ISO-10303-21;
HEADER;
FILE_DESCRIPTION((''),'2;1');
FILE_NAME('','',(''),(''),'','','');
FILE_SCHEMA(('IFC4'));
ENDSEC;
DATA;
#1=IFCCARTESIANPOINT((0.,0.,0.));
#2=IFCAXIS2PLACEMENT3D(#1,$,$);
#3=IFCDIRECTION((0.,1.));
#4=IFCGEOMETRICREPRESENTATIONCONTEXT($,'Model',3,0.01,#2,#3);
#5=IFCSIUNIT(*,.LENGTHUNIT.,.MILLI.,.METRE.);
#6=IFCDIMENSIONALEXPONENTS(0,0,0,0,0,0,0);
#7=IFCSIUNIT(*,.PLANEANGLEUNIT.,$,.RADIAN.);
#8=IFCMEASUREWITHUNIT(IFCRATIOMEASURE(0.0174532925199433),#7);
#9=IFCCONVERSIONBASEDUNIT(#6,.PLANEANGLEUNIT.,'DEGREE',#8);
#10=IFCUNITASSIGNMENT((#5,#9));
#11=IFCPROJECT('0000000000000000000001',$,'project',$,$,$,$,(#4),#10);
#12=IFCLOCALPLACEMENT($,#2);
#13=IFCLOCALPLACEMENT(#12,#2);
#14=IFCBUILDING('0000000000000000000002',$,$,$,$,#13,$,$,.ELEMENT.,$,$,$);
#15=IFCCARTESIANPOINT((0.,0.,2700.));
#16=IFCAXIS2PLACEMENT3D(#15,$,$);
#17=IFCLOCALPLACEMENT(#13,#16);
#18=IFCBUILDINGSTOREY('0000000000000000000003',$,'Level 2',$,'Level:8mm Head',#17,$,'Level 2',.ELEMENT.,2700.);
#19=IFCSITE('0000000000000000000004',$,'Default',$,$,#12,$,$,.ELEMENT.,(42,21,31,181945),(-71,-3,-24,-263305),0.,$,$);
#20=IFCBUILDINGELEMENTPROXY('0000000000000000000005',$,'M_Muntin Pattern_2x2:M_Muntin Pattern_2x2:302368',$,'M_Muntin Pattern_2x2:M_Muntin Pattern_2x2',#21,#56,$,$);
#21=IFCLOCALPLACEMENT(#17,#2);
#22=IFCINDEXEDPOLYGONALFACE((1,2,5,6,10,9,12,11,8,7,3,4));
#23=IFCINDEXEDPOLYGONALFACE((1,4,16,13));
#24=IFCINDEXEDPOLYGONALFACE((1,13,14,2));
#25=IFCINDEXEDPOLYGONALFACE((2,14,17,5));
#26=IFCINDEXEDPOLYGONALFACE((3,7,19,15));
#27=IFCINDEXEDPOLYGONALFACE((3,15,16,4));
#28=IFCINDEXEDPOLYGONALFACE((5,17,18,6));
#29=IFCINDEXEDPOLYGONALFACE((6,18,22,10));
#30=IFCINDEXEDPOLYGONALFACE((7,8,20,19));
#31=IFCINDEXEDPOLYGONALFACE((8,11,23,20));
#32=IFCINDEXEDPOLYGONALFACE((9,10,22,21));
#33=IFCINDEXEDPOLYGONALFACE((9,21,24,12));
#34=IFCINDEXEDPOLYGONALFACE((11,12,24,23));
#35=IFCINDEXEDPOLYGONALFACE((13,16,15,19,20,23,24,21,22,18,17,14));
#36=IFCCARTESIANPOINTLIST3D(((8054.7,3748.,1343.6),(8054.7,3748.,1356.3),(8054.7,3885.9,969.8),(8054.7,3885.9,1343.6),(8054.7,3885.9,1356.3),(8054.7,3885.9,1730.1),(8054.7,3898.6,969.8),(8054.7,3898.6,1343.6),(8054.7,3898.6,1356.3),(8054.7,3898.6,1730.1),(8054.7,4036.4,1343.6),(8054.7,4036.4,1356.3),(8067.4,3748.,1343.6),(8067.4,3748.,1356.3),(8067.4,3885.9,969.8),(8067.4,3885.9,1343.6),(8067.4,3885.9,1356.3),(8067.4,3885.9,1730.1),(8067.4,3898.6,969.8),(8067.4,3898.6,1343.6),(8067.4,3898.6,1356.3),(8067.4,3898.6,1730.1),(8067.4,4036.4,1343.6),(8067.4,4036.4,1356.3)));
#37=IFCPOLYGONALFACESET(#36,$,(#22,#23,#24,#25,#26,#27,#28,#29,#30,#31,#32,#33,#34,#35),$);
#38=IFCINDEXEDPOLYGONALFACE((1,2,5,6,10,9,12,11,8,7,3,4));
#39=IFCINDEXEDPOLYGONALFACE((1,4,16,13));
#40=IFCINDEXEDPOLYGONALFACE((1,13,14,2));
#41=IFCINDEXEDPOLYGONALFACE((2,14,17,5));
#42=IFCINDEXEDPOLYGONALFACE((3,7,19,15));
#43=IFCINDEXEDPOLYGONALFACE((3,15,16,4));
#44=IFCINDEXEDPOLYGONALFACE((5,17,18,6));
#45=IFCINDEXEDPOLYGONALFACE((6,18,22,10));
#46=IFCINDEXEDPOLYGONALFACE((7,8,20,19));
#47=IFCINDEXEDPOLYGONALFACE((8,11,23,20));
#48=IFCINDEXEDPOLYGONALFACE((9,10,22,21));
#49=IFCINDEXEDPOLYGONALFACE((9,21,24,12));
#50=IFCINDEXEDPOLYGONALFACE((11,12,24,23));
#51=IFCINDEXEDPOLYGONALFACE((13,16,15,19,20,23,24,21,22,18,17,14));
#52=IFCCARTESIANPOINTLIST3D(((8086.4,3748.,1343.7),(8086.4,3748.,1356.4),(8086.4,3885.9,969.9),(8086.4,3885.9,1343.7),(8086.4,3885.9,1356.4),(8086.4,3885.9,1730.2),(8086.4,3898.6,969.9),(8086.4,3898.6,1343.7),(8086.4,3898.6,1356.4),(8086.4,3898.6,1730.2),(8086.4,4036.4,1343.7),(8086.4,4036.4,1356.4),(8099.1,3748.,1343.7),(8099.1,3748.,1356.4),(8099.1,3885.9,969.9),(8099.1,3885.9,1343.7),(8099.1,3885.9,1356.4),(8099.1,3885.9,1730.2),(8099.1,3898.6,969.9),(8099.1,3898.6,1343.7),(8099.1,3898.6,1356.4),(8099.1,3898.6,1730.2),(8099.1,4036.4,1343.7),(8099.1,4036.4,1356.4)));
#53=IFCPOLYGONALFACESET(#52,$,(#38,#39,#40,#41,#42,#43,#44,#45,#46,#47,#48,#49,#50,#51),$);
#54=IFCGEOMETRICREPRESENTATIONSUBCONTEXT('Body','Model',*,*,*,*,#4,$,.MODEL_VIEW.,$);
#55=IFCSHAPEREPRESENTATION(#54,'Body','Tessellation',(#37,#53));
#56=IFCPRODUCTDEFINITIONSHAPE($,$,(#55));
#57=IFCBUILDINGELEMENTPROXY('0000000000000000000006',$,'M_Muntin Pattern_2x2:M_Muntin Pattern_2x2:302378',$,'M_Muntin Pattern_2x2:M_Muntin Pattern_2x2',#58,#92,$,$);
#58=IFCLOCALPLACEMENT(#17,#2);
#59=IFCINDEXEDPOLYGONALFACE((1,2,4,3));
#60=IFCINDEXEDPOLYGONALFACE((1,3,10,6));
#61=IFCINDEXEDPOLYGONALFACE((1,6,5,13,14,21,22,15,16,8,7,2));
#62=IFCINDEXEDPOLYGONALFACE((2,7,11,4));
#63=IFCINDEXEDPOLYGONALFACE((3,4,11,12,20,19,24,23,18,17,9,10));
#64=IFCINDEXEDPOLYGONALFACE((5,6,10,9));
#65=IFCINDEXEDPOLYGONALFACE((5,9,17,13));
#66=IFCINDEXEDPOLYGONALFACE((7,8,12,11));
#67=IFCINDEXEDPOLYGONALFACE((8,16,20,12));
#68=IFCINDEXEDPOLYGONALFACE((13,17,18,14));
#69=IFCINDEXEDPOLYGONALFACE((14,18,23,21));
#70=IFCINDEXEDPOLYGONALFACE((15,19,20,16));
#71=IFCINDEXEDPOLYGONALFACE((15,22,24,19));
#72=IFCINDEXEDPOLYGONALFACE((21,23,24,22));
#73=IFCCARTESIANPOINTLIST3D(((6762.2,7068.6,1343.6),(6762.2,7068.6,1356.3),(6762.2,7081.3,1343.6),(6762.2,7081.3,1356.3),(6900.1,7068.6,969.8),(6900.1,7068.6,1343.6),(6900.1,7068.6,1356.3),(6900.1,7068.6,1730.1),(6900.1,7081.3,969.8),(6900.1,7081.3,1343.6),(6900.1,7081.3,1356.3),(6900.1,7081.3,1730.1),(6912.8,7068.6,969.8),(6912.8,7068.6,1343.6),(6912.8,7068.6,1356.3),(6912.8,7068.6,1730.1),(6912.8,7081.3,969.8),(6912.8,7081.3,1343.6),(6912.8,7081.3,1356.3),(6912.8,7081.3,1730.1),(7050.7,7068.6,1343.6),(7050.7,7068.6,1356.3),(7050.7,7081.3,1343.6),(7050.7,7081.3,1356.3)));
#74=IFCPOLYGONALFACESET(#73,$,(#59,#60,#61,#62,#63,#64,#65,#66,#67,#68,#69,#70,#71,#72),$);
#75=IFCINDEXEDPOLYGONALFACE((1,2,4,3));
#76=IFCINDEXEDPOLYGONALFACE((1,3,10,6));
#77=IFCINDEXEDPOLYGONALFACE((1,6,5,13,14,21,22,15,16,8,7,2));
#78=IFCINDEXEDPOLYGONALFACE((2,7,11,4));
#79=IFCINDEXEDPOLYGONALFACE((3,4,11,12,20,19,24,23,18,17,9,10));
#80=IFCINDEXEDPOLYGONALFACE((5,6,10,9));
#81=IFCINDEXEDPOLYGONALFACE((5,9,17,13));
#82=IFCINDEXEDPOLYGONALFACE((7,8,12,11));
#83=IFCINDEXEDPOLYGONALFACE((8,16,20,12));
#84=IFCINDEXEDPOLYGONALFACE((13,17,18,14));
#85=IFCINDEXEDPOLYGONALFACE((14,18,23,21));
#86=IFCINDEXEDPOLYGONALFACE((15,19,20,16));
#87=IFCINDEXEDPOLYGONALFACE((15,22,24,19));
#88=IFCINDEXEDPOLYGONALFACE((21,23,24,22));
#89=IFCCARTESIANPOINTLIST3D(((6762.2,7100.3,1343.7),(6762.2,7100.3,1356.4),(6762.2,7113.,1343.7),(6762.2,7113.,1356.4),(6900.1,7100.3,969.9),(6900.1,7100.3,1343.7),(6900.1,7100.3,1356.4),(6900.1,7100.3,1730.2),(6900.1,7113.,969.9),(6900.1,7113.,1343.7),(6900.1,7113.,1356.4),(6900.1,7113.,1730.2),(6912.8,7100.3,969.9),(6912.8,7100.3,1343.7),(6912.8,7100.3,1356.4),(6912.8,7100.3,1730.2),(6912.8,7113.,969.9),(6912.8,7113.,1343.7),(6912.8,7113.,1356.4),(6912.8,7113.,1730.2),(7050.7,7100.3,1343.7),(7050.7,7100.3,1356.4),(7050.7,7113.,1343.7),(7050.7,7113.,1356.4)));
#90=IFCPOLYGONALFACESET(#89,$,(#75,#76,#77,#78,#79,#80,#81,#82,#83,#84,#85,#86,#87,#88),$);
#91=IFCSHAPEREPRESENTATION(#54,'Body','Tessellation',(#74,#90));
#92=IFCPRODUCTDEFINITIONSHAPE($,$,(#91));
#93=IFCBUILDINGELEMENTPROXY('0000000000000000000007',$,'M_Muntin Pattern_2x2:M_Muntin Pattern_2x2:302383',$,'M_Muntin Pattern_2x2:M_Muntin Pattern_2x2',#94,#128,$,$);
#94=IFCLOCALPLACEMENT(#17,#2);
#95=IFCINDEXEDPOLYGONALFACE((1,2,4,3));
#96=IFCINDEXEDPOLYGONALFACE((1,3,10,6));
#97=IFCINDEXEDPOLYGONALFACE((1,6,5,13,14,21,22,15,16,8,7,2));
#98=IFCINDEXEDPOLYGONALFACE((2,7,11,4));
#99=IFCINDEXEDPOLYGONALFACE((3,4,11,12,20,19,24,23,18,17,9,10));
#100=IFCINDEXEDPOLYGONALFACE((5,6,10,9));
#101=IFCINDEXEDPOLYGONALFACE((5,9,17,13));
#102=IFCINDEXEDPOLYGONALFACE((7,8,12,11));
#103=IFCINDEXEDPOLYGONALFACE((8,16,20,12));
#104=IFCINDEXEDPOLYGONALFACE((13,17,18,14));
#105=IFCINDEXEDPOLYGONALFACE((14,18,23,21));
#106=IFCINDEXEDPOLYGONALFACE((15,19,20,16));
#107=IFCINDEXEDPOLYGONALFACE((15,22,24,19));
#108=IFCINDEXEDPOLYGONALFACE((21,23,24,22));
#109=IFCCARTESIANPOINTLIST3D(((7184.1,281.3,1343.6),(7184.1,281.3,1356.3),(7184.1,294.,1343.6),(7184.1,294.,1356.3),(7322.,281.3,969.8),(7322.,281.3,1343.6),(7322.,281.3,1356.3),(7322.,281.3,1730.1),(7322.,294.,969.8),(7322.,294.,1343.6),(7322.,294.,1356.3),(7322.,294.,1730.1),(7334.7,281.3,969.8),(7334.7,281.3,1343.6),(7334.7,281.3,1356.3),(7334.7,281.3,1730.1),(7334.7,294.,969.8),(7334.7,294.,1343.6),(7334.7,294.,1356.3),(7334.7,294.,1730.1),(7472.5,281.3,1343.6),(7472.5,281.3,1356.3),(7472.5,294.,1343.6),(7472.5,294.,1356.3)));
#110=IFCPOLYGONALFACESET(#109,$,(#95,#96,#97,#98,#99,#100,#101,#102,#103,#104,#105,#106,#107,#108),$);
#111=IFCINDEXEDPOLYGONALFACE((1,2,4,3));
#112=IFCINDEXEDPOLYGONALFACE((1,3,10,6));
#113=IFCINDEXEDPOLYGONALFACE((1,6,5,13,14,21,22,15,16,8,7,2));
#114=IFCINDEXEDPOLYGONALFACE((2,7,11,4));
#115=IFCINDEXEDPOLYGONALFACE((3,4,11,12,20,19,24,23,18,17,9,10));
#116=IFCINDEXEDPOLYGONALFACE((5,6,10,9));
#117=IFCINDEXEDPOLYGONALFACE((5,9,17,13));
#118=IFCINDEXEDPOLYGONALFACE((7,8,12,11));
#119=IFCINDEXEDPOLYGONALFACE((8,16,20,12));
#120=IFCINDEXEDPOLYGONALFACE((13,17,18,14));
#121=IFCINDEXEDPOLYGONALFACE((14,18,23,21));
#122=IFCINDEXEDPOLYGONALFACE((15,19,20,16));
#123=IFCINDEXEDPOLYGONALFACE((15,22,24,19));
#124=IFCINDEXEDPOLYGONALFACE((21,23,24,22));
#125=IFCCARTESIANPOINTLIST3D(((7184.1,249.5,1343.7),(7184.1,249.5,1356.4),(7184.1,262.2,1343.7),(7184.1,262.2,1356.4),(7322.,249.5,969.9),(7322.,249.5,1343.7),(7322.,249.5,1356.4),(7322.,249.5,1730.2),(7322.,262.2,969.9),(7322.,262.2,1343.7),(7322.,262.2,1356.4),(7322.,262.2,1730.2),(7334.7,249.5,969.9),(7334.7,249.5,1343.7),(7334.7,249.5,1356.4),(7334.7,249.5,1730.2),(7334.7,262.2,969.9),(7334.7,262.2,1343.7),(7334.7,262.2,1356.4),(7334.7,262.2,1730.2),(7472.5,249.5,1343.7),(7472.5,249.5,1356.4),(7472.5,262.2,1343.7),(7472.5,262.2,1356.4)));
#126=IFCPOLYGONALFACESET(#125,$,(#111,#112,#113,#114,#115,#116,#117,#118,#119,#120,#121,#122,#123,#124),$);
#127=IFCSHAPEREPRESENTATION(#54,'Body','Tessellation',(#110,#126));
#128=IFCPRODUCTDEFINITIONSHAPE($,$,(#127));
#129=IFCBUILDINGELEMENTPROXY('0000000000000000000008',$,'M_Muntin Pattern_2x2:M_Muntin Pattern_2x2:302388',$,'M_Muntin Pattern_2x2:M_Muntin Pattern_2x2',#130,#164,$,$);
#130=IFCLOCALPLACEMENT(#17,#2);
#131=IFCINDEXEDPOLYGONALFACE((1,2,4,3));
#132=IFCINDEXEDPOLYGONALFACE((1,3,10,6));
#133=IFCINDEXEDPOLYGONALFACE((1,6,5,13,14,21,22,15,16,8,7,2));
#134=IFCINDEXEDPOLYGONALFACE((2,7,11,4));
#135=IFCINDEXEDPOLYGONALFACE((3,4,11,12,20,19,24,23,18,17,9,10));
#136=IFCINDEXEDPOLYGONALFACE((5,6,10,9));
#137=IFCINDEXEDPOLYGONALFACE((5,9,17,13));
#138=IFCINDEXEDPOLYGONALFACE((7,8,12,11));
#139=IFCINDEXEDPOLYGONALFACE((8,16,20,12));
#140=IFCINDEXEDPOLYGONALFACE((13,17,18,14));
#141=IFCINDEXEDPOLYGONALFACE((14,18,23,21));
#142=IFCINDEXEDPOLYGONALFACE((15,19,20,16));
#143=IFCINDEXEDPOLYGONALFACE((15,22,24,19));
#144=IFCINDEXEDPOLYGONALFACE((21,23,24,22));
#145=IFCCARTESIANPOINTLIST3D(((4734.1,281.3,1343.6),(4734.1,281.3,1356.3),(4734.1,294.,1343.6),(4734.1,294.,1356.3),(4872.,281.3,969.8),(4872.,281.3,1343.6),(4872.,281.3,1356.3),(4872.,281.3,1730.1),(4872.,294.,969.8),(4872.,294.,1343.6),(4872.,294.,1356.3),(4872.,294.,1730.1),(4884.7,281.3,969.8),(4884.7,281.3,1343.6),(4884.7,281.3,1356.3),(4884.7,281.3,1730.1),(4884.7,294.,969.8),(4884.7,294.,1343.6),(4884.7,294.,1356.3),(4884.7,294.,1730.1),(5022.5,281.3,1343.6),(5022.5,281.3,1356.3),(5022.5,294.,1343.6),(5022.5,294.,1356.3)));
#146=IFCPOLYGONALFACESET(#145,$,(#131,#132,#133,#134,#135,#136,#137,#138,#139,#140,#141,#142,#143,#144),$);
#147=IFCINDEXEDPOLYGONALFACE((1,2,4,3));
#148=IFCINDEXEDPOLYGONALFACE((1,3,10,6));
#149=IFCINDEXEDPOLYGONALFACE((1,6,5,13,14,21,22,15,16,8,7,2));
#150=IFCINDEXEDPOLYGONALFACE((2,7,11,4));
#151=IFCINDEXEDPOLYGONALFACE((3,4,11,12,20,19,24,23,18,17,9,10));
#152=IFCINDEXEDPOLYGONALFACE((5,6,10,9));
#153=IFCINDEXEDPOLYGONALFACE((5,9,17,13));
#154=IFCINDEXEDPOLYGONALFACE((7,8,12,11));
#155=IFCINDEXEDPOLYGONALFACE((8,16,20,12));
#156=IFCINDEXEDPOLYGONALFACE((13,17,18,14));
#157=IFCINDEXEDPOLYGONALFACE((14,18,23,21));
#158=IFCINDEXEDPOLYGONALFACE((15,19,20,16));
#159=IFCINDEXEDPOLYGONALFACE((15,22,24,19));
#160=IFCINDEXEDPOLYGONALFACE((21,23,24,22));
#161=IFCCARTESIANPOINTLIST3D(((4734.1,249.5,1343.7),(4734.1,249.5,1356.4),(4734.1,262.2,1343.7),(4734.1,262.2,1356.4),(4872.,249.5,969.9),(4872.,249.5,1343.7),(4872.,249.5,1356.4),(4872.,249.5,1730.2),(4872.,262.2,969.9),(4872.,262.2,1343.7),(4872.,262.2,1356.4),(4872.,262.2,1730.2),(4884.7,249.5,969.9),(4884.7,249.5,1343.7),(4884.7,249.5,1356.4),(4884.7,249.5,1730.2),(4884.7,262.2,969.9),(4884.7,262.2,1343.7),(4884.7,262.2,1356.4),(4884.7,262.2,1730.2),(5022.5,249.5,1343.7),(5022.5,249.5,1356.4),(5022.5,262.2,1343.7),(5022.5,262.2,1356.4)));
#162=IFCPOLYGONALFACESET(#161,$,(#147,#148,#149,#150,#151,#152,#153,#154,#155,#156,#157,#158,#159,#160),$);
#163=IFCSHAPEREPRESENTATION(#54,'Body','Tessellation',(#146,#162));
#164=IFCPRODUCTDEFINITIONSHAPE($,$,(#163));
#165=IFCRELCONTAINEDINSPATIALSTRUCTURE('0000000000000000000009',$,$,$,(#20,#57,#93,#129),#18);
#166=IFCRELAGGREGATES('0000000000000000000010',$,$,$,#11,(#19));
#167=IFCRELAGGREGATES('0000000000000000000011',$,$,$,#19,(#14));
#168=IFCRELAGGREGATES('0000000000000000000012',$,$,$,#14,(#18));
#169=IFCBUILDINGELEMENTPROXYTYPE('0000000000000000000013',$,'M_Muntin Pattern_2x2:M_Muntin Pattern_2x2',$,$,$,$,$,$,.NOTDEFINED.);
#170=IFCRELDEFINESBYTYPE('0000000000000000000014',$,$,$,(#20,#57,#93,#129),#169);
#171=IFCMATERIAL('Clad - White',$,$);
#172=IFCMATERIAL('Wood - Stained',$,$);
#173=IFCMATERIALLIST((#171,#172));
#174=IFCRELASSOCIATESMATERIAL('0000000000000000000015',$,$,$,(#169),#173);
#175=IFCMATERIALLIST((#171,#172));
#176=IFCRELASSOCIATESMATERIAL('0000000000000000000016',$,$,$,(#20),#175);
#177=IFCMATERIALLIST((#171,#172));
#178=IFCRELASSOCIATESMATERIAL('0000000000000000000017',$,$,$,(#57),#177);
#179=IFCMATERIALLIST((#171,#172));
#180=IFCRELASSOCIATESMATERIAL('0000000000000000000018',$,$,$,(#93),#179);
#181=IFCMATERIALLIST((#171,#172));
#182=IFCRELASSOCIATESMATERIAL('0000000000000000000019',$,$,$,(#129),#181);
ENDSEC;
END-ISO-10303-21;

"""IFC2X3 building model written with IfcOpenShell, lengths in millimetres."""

from ifc_helpers import new_model, entity, si_unit, converted_unit, direction, frame, origin, place, context, subcontext, project, spatial, polyline, outline, extrude, source, transform, mapped, material, material_list, type_object, type_shapes, element, save


model = new_model("IFC2X3")

# Units and contexts
model_context = context("Model", 3, precision=0.01, world=origin(), true_north=direction((0.0, 1.0)))
body_context = subcontext(model_context, "Body", "Model", "MODEL_VIEW")
ifc_project = project(units=[si_unit("LENGTHUNIT", "METRE", prefix="MILLI"), converted_unit("PLANEANGLEUNIT", "DEGREE", entity("IfcRatioMeasure", 0.0174532925199433), si_unit("PLANEANGLEUNIT", "RADIAN"), dimensions=[0, 0, 0, 0, 0, 0, 0])], contexts=[model_context])

# Site, building, storey
site_placement = place(None, origin())
site = spatial("IfcSite", under=ifc_project, at=site_placement, Name="Default", CompositionType="ELEMENT", RefLatitude=(42, 21, 31, 181945), RefLongitude=(-71, -3, -24, -263305), RefElevation=0.0)
building_placement = place(site_placement, origin())
building = spatial("IfcBuilding", under=site, at=building_placement, CompositionType="ELEMENT")
storey_placement = place(building_placement, frame((0.0, 0.0, 2700.0)))
storey = spatial("IfcBuildingStorey", under=building, at=storey_placement, Name="Level 2", ObjectType="Level:8mm Head", LongName="Level 2", CompositionType="ELEMENT", Elevation=2700.0)

# Building element proxies
ifc_material_1 = material(Name="Clad - White")
ifc_material_2 = material(Name="Wood - Stained")
ifc_material_list_1 = material_list([ifc_material_1, ifc_material_2])
ifc_material_list_2 = material_list([ifc_material_1, ifc_material_2])
building_element_proxy_type_1 = type_object("IfcBuildingElementProxyType", Name="M_Muntin Pattern_2x2:M_Muntin Pattern_2x2", PredefinedType="NOTDEFINED", material=ifc_material_list_2)
shared_shape_1 = source(origin(), body_context, "Body", "SweptSolid", [
    extrude(outline(polyline([(6.4, -6.4), (380.1, -6.4), (380.1, 6.3), (6.4, 6.3), (6.4, 144.2), (-6.3, 144.2), (-6.3, 6.3), (-380.2, 6.3), (-380.2, -6.4), (-6.3, -6.4), (-6.3, -144.2), (6.4, -144.2), (6.4, -6.4)])), frame((0.0, -22.2, 380.1), z_axis=(0.0, 1.0, 0.0), x_axis=(0.0, 0.0, 1.0)), (0.0, 0.0, 1.0), 12.7),
    extrude(outline(polyline([(6.4, -6.4), (380.2, -6.4), (380.2, 6.3), (6.4, 6.3), (6.4, 144.2), (-6.3, 144.2), (-6.3, 6.3), (-380.2, 6.3), (-380.2, -6.4), (-6.3, -6.4), (-6.3, -144.2), (6.4, -144.2), (6.4, -6.4)])), frame((0.0, 9.5, 380.2), z_axis=(0.0, 1.0, 0.0), x_axis=(0.0, 0.0, 1.0)), (0.0, 0.0, 1.0), 12.7),
])
type_shapes(building_element_proxy_type_1, [shared_shape_1])
proxy_1_placement = place(storey_placement, frame((8076.9, 3892.2, 969.9), z_axis=(0.0, 0.0, 1.0), x_axis=(0.0, -1.0, 0.0)))
element("IfcBuildingElementProxy", 1, at=proxy_1_placement, inside=storey, type_object=building_element_proxy_type_1, material=ifc_material_list_1, Name="M_Muntin Pattern_2x2:M_Muntin Pattern_2x2:302368", ObjectType="M_Muntin Pattern_2x2:M_Muntin Pattern_2x2", context=body_context, shape_type="MappedRepresentation", body=[
    mapped(shared_shape_1, transform((0.0, 0.0, 0.0), scale=1.0)),
])
ifc_material_list_3 = material_list([ifc_material_1, ifc_material_2])
proxy_2_placement = place(storey_placement, frame((6906.5, 7090.8, 969.9)))
element("IfcBuildingElementProxy", 2, at=proxy_2_placement, inside=storey, type_object=building_element_proxy_type_1, material=ifc_material_list_3, Name="M_Muntin Pattern_2x2:M_Muntin Pattern_2x2:302378", ObjectType="M_Muntin Pattern_2x2:M_Muntin Pattern_2x2", context=body_context, shape_type="MappedRepresentation", body=[
    mapped(shared_shape_1, transform((0.0, 0.0, 0.0), scale=1.0)),
])
ifc_material_list_4 = material_list([ifc_material_1, ifc_material_2])
proxy_3_placement = place(storey_placement, frame((7328.3, 271.8, 969.9), z_axis=(0.0, 0.0, 1.0), x_axis=(-1.0, 0.0, 0.0)))
element("IfcBuildingElementProxy", 3, at=proxy_3_placement, inside=storey, type_object=building_element_proxy_type_1, material=ifc_material_list_4, Name="M_Muntin Pattern_2x2:M_Muntin Pattern_2x2:302383", ObjectType="M_Muntin Pattern_2x2:M_Muntin Pattern_2x2", context=body_context, shape_type="MappedRepresentation", body=[
    mapped(shared_shape_1, transform((0.0, 0.0, 0.0), scale=1.0)),
])
ifc_material_list_5 = material_list([ifc_material_1, ifc_material_2])
proxy_4_placement = place(storey_placement, frame((4878.3, 271.8, 969.9), z_axis=(0.0, 0.0, 1.0), x_axis=(-1.0, 0.0, 0.0)))
element("IfcBuildingElementProxy", 4, at=proxy_4_placement, inside=storey, type_object=building_element_proxy_type_1, material=ifc_material_list_5, Name="M_Muntin Pattern_2x2:M_Muntin Pattern_2x2:302388", ObjectType="M_Muntin Pattern_2x2:M_Muntin Pattern_2x2", context=body_context, shape_type="MappedRepresentation", body=[
    mapped(shared_shape_1, transform((0.0, 0.0, 0.0), scale=1.0)),
])

save(model, "model.ifc")
